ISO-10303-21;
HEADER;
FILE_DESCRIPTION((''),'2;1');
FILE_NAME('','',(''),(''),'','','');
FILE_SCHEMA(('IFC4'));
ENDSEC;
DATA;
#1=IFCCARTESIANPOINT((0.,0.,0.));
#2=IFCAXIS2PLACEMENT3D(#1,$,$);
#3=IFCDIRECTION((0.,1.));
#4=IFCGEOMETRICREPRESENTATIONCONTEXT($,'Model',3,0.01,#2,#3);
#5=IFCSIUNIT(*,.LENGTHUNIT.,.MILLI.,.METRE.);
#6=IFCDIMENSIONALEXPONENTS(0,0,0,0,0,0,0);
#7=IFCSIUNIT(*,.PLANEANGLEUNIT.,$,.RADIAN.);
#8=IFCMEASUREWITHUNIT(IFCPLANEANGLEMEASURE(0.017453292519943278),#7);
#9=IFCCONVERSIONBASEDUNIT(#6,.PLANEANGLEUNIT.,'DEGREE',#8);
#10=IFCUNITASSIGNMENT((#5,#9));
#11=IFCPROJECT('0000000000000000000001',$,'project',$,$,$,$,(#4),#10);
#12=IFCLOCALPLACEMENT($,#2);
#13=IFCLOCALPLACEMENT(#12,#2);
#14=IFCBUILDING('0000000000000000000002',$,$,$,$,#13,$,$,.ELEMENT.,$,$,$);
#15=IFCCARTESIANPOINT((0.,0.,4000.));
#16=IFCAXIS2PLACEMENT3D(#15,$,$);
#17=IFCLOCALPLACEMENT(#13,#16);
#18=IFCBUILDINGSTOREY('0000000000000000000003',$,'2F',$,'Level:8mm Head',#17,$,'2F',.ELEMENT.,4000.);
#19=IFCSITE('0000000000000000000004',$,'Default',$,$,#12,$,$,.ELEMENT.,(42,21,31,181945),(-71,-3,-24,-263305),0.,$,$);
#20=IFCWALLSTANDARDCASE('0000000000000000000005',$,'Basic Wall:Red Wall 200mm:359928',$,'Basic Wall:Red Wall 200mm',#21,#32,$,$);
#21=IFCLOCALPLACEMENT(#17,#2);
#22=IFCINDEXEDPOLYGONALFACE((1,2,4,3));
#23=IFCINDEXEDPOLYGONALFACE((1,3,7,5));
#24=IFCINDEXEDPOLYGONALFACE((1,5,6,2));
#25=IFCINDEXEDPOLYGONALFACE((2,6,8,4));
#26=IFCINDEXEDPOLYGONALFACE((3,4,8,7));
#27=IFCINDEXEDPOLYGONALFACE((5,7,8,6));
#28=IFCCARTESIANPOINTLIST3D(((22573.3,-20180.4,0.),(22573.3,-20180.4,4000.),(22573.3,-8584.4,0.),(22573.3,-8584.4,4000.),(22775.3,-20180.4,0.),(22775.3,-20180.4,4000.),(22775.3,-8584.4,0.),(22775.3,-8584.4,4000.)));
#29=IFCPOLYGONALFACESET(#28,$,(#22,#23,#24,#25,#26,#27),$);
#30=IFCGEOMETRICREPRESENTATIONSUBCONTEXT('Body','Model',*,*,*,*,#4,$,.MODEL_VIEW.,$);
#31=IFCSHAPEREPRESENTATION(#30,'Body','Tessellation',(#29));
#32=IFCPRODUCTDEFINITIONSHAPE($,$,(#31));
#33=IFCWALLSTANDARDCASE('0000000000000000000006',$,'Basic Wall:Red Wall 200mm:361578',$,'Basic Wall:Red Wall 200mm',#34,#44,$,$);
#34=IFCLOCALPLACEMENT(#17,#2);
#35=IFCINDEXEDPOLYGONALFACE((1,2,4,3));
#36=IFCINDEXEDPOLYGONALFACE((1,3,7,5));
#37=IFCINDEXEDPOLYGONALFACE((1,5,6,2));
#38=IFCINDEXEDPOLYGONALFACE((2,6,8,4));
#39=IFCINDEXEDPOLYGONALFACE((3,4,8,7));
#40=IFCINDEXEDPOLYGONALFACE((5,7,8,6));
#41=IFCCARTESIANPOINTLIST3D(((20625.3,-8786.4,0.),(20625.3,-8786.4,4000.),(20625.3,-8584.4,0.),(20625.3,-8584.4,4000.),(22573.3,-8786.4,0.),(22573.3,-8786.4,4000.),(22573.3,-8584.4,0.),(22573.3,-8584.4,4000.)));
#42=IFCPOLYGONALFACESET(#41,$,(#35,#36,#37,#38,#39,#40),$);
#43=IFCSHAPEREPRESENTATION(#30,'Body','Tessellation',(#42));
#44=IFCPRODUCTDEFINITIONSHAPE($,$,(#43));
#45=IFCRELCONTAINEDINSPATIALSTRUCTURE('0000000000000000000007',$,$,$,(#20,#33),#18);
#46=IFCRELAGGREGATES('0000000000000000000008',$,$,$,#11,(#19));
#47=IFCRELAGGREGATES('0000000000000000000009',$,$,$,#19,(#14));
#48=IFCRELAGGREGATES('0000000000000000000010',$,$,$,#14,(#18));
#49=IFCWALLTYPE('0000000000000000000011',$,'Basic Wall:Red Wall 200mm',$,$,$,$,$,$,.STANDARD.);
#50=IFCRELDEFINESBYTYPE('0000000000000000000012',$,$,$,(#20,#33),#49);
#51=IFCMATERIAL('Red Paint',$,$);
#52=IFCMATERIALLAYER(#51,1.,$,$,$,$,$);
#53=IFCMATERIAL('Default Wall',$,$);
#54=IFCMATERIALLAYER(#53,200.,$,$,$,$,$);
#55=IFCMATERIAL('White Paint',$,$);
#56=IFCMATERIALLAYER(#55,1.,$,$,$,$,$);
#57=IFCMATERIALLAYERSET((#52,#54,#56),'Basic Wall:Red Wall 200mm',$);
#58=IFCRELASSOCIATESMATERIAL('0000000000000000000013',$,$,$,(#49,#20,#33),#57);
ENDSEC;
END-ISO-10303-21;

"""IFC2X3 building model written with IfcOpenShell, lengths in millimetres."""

from ifc_helpers import new_model, entity, si_unit, converted_unit, direction, frame, frame_2d, origin, place, context, subcontext, project, spatial, rectangle, extrude, material, layer, layer_set, layer_usage, type_object, element, save


model = new_model("IFC2X3")

# Units and contexts
model_context = context("Model", 3, precision=0.01, world=origin(), true_north=direction((0.0, 1.0)))
body_context = subcontext(model_context, "Body", "Model", "MODEL_VIEW")
ifc_project = project(units=[si_unit("LENGTHUNIT", "METRE", prefix="MILLI"), converted_unit("PLANEANGLEUNIT", "DEGREE", entity("IfcPlaneAngleMeasure", 0.017453292519943278), si_unit("PLANEANGLEUNIT", "RADIAN"), dimensions=[0, 0, 0, 0, 0, 0, 0])], contexts=[model_context])

# Site, building, storey
site_placement = place(None, origin())
site = spatial("IfcSite", under=ifc_project, at=site_placement, Name="Default", CompositionType="ELEMENT", RefLatitude=(42, 21, 31, 181945), RefLongitude=(-71, -3, -24, -263305), RefElevation=0.0)
building_placement = place(site_placement, origin())
building = spatial("IfcBuilding", under=site, at=building_placement, CompositionType="ELEMENT")
storey_placement = place(building_placement, frame((0.0, 0.0, 4000.0)))
storey = spatial("IfcBuildingStorey", under=building, at=storey_placement, Name="2F", ObjectType="Level:8mm Head", LongName="2F", CompositionType="ELEMENT", Elevation=4000.0)

# Shared definitions
ifc_material_1 = material(Name="White Paint")
ifc_material_2 = material(Name="Default Wall")

# Walls
ifc_material_3 = material(Name="Red Paint")
ifc_layer_1 = layer(ifc_material_3, 1.0)
ifc_layer_2 = layer(ifc_material_2, 200.0)
ifc_layer_3 = layer(ifc_material_1, 1.0)
ifc_layer_set_1 = layer_set([ifc_layer_1, ifc_layer_2, ifc_layer_3], Name="Basic Wall:Red Wall 200mm")
ifc_layer_usage_1 = layer_usage(ifc_layer_set_1, "AXIS2", "POSITIVE", -101.0)
wall_type_1 = type_object("IfcWallType", Name="Basic Wall:Red Wall 200mm", PredefinedType="STANDARD", material=ifc_layer_set_1)
wall_1_placement = place(storey_placement, frame((22674.3, -20180.4, 0.0), z_axis=(0.0, 0.0, 1.0), x_axis=(0.0, 1.0, 0.0)))
element("IfcWallStandardCase", 1, at=wall_1_placement, inside=storey, type_object=wall_type_1, material=ifc_layer_usage_1, Name="Basic Wall:Red Wall 200mm:359928", ObjectType="Basic Wall:Red Wall 200mm", context=body_context, shape_type="SweptSolid", body=[
    extrude(rectangle(XDim=11596.0, YDim=202.0, at=frame_2d((5798.0, 0.0), x_axis=(-1.0, 0.0))), origin(), (0.0, 0.0, 1.0), 4000.0),
])
ifc_layer_usage_2 = layer_usage(ifc_layer_set_1, "AXIS2", "POSITIVE", -101.0)
wall_2_placement = place(storey_placement, frame((22573.3, -8685.4, 0.0), z_axis=(0.0, 0.0, 1.0), x_axis=(-1.0, 0.0, 0.0)))
element("IfcWallStandardCase", 2, at=wall_2_placement, inside=storey, type_object=wall_type_1, material=ifc_layer_usage_2, Name="Basic Wall:Red Wall 200mm:361578", ObjectType="Basic Wall:Red Wall 200mm", context=body_context, shape_type="SweptSolid", body=[
    extrude(rectangle(XDim=1948.0, YDim=202.0, at=frame_2d((974.0, 0.0), x_axis=(-1.0, 0.0))), origin(), (0.0, 0.0, 1.0), 4000.0),
])

save(model, "model.ifc")
